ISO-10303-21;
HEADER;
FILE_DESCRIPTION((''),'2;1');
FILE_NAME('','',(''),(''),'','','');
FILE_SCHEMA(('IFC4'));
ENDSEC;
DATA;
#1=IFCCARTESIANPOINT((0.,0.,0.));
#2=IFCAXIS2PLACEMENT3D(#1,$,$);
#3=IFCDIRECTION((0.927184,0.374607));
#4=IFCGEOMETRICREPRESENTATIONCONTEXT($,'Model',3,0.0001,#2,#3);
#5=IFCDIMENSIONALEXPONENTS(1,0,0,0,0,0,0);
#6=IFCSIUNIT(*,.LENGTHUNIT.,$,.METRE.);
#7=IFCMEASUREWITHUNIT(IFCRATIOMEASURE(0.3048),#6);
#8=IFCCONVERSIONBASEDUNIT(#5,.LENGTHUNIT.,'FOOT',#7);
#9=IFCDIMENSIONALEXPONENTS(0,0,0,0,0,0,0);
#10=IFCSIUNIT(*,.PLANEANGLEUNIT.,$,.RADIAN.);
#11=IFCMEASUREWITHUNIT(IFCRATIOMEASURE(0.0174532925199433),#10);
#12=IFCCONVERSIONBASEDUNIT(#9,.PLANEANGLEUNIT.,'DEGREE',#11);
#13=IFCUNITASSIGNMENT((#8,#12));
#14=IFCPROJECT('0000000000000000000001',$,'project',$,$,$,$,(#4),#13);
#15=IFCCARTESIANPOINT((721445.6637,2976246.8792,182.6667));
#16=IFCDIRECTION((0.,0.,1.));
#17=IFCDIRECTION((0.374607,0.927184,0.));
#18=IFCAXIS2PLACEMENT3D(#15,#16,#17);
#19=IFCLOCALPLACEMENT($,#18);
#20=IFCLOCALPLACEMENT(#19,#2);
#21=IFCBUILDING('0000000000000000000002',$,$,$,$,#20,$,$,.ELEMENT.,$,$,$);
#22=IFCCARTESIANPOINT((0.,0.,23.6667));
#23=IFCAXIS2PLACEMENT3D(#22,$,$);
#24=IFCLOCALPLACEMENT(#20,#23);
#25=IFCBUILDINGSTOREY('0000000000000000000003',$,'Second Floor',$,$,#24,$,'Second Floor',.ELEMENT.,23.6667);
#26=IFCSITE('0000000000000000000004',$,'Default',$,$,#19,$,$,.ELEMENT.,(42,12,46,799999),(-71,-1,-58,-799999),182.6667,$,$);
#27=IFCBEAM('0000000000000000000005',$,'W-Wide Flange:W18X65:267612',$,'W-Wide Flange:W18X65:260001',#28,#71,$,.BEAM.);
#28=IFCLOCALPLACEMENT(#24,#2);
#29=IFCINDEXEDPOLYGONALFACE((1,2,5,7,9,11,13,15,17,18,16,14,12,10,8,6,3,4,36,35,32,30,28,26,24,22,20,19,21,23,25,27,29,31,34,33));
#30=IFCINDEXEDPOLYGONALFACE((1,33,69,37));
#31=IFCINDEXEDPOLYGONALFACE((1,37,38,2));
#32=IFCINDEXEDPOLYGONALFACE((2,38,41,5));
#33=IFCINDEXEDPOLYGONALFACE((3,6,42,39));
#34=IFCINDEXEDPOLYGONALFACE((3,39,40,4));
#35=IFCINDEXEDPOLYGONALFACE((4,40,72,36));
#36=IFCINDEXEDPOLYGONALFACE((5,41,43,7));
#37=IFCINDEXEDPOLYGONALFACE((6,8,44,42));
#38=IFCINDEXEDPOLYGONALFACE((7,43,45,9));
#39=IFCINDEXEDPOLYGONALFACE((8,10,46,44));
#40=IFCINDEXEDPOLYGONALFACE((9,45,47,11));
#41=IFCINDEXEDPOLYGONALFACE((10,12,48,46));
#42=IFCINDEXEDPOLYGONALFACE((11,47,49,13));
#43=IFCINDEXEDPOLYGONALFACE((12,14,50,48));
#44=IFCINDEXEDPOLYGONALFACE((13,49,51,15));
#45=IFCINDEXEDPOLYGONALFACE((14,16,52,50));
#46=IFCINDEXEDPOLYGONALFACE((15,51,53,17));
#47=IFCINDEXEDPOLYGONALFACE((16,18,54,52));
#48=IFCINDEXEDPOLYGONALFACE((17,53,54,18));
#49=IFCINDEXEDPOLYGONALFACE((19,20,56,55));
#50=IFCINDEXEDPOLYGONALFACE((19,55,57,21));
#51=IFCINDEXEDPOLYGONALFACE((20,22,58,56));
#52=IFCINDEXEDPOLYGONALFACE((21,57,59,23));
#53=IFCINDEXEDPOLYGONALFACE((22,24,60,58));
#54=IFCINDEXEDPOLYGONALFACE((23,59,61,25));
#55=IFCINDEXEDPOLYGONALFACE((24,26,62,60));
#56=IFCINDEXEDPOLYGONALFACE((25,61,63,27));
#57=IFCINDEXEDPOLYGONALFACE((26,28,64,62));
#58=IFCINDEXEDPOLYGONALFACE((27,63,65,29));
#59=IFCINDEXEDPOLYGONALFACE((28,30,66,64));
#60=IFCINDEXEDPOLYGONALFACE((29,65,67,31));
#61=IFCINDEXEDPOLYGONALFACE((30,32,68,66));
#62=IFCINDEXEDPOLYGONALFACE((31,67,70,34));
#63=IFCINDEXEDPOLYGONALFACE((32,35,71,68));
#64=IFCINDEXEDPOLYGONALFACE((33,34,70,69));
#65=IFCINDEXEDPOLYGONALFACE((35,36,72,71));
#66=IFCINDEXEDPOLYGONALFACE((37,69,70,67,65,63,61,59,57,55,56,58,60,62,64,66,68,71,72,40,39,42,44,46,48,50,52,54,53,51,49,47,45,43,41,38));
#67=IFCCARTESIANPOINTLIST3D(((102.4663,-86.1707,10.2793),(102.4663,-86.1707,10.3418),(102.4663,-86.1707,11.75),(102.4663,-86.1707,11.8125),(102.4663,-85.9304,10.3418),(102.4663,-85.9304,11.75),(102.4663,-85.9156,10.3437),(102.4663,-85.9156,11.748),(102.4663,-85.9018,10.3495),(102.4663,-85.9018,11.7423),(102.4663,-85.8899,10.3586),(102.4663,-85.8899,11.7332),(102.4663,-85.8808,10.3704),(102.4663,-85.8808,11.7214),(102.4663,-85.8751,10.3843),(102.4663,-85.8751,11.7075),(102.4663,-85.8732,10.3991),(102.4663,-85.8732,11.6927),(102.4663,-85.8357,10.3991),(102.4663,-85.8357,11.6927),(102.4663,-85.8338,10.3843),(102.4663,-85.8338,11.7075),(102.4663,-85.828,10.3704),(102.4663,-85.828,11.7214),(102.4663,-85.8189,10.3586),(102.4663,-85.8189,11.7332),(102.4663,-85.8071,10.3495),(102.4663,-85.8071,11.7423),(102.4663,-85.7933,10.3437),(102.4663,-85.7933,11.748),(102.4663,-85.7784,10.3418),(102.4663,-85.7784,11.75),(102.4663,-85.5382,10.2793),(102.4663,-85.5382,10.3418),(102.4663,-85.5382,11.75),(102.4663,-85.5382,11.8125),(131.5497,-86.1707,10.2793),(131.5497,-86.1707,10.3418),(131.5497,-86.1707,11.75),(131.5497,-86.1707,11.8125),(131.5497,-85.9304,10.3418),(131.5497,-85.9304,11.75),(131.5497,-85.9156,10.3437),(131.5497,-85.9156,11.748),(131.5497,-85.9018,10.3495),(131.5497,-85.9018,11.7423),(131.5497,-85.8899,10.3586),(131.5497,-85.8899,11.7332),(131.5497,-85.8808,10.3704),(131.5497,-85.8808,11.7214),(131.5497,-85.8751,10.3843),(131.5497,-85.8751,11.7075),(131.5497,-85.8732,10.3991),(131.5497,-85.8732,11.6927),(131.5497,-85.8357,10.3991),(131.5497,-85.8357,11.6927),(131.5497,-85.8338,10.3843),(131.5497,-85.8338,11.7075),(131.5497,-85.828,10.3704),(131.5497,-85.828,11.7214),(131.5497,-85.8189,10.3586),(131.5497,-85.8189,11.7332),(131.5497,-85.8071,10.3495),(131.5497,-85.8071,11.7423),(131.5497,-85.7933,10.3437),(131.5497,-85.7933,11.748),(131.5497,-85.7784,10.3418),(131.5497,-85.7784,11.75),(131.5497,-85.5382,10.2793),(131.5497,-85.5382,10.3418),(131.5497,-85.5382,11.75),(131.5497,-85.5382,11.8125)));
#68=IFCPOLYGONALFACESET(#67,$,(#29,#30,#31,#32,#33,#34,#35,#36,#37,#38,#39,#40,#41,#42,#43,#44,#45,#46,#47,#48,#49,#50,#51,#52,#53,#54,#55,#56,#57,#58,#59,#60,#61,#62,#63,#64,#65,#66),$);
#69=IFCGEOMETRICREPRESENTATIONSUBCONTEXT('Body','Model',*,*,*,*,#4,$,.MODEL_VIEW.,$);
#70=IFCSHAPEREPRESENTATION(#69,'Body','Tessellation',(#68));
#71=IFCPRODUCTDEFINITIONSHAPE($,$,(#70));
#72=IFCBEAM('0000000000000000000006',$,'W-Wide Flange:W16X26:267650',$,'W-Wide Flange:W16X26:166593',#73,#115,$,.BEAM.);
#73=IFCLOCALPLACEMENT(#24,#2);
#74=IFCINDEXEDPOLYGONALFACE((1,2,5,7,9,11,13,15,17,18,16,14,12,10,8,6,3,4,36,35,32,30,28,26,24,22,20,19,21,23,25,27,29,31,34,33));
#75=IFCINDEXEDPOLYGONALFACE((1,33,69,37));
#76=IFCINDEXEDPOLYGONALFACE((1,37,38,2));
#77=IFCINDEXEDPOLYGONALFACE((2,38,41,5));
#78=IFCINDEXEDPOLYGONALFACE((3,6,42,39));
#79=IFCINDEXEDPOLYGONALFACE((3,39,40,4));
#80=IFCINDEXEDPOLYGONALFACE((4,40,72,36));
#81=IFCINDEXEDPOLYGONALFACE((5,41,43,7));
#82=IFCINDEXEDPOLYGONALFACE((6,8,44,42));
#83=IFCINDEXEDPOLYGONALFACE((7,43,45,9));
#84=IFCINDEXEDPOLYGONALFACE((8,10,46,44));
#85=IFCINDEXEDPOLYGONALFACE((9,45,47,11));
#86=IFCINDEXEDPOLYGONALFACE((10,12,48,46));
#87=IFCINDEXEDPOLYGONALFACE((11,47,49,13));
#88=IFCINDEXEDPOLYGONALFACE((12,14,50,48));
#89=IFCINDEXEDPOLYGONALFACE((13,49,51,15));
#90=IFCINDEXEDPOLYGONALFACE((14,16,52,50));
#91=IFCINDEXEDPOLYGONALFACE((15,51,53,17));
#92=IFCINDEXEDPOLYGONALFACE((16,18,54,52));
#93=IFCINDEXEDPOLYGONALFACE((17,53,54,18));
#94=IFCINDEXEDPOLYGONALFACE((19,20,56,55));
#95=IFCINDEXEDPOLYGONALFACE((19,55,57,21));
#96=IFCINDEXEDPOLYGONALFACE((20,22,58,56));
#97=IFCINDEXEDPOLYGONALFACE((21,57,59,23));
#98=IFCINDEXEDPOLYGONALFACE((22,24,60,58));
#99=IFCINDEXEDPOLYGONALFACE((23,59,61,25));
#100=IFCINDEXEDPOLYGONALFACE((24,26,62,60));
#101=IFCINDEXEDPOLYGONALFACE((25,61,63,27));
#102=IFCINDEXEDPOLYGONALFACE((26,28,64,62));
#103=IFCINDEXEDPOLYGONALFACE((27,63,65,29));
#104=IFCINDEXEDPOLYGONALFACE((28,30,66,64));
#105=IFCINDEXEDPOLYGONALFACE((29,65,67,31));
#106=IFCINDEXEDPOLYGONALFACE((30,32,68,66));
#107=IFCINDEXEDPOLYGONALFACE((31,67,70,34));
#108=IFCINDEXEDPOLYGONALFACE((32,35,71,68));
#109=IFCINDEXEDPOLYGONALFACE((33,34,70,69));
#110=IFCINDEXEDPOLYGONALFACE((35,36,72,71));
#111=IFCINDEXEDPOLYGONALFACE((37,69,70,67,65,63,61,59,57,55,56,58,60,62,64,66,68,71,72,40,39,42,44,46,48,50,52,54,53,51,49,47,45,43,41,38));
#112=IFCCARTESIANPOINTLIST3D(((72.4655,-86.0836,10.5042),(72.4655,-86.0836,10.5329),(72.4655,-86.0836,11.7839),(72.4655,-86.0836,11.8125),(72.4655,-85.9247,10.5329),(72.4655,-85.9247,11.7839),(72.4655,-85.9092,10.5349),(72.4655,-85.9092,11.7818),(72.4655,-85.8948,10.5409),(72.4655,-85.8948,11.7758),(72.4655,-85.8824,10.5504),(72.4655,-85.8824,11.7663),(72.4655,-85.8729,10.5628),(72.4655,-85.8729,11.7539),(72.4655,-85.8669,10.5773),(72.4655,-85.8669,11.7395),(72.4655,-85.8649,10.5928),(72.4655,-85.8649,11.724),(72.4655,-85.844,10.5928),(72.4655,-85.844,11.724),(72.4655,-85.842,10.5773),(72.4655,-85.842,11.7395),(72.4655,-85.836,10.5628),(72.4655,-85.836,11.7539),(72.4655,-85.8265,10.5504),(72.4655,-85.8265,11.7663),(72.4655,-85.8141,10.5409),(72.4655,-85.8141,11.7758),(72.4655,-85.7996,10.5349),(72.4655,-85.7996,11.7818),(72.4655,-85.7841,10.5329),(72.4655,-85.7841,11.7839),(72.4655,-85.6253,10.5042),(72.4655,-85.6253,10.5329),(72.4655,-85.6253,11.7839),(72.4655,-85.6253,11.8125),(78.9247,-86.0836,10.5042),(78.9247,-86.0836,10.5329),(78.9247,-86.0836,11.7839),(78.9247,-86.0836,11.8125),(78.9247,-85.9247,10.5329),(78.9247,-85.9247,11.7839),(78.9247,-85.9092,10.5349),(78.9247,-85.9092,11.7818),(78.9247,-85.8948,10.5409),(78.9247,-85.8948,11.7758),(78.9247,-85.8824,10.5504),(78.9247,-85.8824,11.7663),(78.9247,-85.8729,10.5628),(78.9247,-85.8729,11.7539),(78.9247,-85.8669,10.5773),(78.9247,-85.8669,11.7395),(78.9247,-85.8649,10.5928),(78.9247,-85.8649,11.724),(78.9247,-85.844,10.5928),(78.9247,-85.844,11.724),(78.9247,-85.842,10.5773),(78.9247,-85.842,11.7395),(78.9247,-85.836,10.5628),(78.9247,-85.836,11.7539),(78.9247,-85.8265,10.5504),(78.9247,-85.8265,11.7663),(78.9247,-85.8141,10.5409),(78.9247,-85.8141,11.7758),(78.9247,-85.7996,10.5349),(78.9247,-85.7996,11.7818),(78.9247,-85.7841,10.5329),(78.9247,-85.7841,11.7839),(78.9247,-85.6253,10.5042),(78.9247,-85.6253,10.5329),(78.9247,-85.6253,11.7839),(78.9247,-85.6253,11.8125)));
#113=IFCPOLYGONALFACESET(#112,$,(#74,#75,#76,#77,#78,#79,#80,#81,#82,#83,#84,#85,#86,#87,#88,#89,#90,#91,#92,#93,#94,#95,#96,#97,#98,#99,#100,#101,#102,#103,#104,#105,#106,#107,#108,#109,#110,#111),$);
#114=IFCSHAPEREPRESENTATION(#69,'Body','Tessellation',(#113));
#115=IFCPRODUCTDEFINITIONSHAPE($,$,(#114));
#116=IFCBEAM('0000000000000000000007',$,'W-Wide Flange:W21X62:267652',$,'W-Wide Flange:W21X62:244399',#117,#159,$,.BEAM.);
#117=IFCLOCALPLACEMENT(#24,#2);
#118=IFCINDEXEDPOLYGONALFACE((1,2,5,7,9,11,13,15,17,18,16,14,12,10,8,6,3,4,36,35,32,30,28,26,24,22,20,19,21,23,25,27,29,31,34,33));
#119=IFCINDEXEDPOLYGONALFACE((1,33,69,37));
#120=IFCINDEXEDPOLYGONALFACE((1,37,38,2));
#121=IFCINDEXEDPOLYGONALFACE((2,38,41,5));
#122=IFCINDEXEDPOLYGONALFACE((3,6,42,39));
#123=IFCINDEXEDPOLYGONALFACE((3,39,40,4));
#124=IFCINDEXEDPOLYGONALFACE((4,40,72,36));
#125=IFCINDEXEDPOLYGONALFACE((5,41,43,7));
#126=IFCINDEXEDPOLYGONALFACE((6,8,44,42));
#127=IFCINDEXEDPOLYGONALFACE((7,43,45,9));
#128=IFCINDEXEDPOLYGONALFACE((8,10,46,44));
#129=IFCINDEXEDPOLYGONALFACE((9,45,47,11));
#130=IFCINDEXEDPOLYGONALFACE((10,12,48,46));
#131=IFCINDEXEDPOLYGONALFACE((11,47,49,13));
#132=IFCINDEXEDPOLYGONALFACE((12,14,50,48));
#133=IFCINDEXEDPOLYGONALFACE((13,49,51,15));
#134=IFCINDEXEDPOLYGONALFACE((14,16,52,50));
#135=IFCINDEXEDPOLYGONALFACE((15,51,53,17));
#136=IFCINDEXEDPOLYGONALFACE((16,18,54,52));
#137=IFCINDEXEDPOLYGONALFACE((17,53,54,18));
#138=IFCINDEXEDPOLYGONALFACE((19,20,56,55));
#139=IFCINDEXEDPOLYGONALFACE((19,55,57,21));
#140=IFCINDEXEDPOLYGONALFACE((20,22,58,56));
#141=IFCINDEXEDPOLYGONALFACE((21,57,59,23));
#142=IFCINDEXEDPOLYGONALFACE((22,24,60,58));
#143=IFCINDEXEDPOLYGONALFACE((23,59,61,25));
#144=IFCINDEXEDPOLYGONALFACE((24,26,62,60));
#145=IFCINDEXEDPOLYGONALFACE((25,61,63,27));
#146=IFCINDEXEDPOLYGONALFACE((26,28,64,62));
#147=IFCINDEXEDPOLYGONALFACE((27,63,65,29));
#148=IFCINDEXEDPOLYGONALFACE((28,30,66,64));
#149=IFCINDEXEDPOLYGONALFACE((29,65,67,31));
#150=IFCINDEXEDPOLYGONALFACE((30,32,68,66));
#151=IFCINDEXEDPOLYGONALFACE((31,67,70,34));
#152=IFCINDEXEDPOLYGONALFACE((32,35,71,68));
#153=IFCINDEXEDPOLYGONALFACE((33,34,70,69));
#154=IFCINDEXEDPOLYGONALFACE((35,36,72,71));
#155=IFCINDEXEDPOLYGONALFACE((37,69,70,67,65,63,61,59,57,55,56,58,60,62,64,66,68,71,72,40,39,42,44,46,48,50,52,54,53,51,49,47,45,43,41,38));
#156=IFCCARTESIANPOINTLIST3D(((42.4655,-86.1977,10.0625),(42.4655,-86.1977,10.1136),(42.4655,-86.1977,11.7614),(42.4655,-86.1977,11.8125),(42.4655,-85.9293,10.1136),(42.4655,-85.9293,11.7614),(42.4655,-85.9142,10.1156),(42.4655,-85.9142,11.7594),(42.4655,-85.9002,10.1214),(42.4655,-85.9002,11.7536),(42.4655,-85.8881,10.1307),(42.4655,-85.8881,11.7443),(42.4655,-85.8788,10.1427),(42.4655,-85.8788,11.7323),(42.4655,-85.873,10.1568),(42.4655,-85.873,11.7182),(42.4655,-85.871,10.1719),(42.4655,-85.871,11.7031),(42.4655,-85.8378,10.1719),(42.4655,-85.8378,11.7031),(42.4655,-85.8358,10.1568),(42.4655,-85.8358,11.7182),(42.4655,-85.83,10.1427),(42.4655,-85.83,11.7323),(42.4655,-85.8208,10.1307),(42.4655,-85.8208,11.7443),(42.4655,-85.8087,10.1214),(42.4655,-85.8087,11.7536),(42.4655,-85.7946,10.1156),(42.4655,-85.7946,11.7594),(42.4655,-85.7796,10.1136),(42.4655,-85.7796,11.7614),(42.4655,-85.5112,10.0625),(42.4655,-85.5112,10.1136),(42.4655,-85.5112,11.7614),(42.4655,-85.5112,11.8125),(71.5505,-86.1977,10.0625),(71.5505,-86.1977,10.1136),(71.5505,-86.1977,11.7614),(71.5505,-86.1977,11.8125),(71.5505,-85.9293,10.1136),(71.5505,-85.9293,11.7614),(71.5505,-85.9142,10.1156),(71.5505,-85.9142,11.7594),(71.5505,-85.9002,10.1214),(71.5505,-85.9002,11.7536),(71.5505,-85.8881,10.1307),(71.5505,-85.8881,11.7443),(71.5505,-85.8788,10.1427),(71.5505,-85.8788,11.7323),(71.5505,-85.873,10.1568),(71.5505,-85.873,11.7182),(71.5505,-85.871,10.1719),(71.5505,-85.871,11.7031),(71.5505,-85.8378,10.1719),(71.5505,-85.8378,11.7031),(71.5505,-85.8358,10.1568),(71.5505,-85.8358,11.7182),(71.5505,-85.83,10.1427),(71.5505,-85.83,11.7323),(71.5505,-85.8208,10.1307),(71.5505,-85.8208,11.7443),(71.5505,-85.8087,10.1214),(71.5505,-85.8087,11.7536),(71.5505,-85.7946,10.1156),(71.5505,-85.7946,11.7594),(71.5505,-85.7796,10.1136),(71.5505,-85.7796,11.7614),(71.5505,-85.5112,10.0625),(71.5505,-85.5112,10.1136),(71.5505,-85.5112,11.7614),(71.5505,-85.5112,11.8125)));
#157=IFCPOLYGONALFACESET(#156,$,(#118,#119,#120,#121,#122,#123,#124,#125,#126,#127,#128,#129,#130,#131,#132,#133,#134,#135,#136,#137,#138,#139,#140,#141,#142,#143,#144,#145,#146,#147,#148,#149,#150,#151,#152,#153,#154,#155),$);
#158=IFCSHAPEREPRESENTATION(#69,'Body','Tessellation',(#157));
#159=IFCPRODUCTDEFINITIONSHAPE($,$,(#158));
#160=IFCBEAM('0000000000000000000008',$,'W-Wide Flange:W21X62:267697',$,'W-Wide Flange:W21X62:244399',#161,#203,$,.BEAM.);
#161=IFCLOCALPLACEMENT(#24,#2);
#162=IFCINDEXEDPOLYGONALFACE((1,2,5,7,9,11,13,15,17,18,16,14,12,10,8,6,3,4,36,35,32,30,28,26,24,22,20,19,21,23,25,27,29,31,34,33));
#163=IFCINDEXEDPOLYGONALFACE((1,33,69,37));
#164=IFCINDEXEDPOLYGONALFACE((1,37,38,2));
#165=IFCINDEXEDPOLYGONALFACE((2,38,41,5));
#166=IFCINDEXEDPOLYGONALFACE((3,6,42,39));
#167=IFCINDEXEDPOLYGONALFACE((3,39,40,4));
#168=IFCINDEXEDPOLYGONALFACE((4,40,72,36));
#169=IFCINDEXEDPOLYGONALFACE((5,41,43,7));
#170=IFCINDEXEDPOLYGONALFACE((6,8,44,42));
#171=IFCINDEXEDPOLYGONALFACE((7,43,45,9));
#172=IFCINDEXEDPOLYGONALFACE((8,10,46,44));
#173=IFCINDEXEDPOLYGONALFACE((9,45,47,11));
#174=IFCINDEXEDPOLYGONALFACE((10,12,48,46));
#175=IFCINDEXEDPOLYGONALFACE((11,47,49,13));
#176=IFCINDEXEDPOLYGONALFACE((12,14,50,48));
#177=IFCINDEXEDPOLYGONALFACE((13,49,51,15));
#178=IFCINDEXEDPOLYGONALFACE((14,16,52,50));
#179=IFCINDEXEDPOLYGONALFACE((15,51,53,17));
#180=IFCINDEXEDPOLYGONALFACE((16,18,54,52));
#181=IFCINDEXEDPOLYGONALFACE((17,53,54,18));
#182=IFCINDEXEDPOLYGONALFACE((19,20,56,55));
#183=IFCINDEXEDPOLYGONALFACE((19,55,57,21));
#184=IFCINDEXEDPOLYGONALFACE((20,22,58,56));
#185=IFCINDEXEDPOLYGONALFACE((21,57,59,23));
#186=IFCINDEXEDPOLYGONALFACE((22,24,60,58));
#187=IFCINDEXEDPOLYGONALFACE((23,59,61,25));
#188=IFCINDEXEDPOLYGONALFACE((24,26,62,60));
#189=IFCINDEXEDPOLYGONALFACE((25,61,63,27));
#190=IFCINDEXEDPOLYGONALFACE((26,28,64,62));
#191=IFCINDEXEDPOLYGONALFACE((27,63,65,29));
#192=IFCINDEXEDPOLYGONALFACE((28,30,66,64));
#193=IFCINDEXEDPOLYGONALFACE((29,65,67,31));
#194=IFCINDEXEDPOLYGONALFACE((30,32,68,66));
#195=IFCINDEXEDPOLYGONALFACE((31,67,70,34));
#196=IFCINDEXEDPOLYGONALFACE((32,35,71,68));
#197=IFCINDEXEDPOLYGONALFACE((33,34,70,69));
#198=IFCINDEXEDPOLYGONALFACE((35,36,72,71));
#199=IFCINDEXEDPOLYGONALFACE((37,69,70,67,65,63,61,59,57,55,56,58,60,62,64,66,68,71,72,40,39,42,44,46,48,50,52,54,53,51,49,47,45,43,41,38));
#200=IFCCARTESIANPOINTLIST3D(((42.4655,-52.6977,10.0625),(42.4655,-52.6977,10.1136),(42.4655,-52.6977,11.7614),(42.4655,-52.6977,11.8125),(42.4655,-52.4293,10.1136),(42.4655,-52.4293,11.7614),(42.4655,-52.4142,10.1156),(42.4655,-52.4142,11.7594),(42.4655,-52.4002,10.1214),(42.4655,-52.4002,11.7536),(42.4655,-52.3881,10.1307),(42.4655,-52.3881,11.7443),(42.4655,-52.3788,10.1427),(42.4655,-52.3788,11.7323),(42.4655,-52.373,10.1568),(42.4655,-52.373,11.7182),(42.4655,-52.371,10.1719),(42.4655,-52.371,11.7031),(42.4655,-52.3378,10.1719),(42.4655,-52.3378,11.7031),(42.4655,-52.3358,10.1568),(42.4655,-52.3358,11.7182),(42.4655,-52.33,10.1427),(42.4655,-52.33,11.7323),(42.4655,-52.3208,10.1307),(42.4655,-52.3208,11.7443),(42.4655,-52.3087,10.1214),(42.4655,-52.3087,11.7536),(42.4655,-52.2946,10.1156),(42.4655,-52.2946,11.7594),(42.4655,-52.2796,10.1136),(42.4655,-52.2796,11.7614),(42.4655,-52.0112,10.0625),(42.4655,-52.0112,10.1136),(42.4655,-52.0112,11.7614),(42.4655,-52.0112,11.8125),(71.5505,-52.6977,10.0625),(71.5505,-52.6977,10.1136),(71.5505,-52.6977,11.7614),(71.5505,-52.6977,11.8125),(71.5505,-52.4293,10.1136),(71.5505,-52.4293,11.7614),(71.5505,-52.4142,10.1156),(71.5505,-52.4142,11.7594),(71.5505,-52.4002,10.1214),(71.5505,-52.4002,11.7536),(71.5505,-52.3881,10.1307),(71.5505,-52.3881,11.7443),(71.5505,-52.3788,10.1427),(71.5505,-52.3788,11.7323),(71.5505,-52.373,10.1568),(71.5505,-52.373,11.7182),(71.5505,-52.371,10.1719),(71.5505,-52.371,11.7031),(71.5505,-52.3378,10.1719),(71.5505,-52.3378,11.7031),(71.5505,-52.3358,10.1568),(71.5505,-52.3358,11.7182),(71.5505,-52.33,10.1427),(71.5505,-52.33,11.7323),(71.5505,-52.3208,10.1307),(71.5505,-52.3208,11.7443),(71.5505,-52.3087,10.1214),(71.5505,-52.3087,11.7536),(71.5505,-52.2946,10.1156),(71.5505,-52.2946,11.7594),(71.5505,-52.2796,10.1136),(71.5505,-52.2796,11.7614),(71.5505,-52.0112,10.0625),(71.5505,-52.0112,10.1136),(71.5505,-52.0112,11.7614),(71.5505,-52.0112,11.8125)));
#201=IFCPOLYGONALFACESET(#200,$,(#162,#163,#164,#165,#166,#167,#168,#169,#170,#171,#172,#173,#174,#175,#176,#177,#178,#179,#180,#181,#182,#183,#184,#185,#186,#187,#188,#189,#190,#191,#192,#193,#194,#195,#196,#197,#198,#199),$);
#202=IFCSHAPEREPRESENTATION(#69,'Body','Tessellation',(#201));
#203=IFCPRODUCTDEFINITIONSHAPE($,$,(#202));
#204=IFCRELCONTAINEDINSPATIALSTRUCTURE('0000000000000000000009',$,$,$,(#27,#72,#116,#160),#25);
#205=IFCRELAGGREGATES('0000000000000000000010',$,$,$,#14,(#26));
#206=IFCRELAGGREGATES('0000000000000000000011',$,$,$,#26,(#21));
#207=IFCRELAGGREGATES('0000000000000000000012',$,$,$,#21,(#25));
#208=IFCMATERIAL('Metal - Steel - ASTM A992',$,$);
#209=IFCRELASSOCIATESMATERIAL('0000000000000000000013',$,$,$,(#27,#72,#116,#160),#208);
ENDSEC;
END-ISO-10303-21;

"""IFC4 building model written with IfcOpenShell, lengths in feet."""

from ifc_helpers import new_model, entity, si_unit, converted_unit, direction, frame, frame_2d, origin, place, context, subcontext, project, spatial, i_section, extrude, material, element, save


model = new_model("IFC4")

# Units and contexts
model_context = context("Model", 3, precision=0.0001, world=origin(), true_north=direction((0.927184, 0.374607)))
body_context = subcontext(model_context, "Body", "Model", "MODEL_VIEW")
ifc_project = project(units=[converted_unit("LENGTHUNIT", "FOOT", entity("IfcRatioMeasure", 0.3048), si_unit("LENGTHUNIT", "METRE"), dimensions=[1, 0, 0, 0, 0, 0, 0]), converted_unit("PLANEANGLEUNIT", "DEGREE", entity("IfcRatioMeasure", 0.0174532925199433), si_unit("PLANEANGLEUNIT", "RADIAN"), dimensions=[0, 0, 0, 0, 0, 0, 0])], contexts=[model_context])

# Site, building, storey
site_placement = place(None, frame((721445.6637, 2976246.8792, 182.6667), z_axis=(0.0, 0.0, 1.0), x_axis=(0.374607, 0.927184, 0.0)))
site = spatial("IfcSite", under=ifc_project, at=site_placement, Name="Default", CompositionType="ELEMENT", RefLatitude=(42, 12, 46, 799999), RefLongitude=(-71, -1, -58, -799999), RefElevation=182.6667)
building_placement = place(site_placement, origin())
building = spatial("IfcBuilding", under=site, at=building_placement, CompositionType="ELEMENT")
storey_placement = place(building_placement, frame((0.0, 0.0, 23.6667)))
storey = spatial("IfcBuildingStorey", under=building, at=storey_placement, Name="Second Floor", LongName="Second Floor", CompositionType="ELEMENT", Elevation=23.6667)

# Shared definitions
ifc_material_1 = material(Name="Metal - Steel - ASTM A992")

# Beams
beam_1_placement = place(storey_placement, frame((102.008, -85.8544, 11.8125)))
element("IfcBeam", 1, at=beam_1_placement, inside=storey, material=ifc_material_1, Name="W-Wide Flange:W18X65:267612", ObjectType="W-Wide Flange:W18X65:260001", PredefinedType="BEAM", context=body_context, shape_type="SweptSolid", body=[
    extrude(i_section(OverallWidth=0.6325, OverallDepth=1.5332, WebThickness=0.0374, FlangeThickness=0.0625, FilletRadius=0.0573, at=frame_2d((0.0, 0.0), x_axis=(0.0, 1.0))), frame((0.4583, 0.0, -0.7666), z_axis=(1.0, 0.0, 0.0), x_axis=(0.0, 0.0, -1.0)), (0.0, 0.0, 1.0), 29.0833),
])
beam_2_placement = place(storey_placement, frame((79.383, -85.8544, 11.8125), z_axis=(0.0, 0.0, 1.0), x_axis=(-1.0, 0.0, 0.0)))
element("IfcBeam", 2, at=beam_2_placement, inside=storey, material=ifc_material_1, Name="W-Wide Flange:W16X26:267650", ObjectType="W-Wide Flange:W16X26:166593", PredefinedType="BEAM", context=body_context, shape_type="SweptSolid", body=[
    extrude(i_section(OverallWidth=0.4583, OverallDepth=1.3083, WebThickness=0.0208, FlangeThickness=0.0286, FilletRadius=0.0599, at=frame_2d((0.0, 0.0), x_axis=(0.0, 1.0))), frame((0.4583, 0.0, -0.6541), z_axis=(1.0, 0.0, 0.0), x_axis=(0.0, 0.0, -1.0)), (0.0, 0.0, 1.0), 6.4591),
])
beam_3_placement = place(storey_placement, frame((72.008, -85.8544, 11.8125), z_axis=(0.0, 0.0, 1.0), x_axis=(-1.0, 0.0, 0.0)))
element("IfcBeam", 3, at=beam_3_placement, inside=storey, material=ifc_material_1, Name="W-Wide Flange:W21X62:267652", ObjectType="W-Wide Flange:W21X62:244399", PredefinedType="BEAM", context=body_context, shape_type="SweptSolid", body=[
    extrude(i_section(OverallWidth=0.6865, OverallDepth=1.75, WebThickness=0.0332, FlangeThickness=0.0511, FilletRadius=0.0583, at=frame_2d((0.0, 0.0), x_axis=(0.0, 1.0))), frame((0.4575, 0.0, -0.875), z_axis=(1.0, 0.0, 0.0), x_axis=(0.0, 0.0, -1.0)), (0.0, 0.0, 1.0), 29.085),
])
beam_4_placement = place(storey_placement, frame((72.008, -52.3544, 11.8125), z_axis=(0.0, 0.0, 1.0), x_axis=(-1.0, 0.0, 0.0)))
element("IfcBeam", 4, at=beam_4_placement, inside=storey, material=ifc_material_1, Name="W-Wide Flange:W21X62:267697", ObjectType="W-Wide Flange:W21X62:244399", PredefinedType="BEAM", context=body_context, shape_type="SweptSolid", body=[
    extrude(i_section(OverallWidth=0.6865, OverallDepth=1.75, WebThickness=0.0332, FlangeThickness=0.0511, FilletRadius=0.0583, at=frame_2d((0.0, 0.0), x_axis=(0.0, 1.0))), frame((0.4575, 0.0, -0.875), z_axis=(1.0, 0.0, 0.0), x_axis=(0.0, 0.0, -1.0)), (0.0, 0.0, 1.0), 29.085),
])

save(model, "model.ifc")
